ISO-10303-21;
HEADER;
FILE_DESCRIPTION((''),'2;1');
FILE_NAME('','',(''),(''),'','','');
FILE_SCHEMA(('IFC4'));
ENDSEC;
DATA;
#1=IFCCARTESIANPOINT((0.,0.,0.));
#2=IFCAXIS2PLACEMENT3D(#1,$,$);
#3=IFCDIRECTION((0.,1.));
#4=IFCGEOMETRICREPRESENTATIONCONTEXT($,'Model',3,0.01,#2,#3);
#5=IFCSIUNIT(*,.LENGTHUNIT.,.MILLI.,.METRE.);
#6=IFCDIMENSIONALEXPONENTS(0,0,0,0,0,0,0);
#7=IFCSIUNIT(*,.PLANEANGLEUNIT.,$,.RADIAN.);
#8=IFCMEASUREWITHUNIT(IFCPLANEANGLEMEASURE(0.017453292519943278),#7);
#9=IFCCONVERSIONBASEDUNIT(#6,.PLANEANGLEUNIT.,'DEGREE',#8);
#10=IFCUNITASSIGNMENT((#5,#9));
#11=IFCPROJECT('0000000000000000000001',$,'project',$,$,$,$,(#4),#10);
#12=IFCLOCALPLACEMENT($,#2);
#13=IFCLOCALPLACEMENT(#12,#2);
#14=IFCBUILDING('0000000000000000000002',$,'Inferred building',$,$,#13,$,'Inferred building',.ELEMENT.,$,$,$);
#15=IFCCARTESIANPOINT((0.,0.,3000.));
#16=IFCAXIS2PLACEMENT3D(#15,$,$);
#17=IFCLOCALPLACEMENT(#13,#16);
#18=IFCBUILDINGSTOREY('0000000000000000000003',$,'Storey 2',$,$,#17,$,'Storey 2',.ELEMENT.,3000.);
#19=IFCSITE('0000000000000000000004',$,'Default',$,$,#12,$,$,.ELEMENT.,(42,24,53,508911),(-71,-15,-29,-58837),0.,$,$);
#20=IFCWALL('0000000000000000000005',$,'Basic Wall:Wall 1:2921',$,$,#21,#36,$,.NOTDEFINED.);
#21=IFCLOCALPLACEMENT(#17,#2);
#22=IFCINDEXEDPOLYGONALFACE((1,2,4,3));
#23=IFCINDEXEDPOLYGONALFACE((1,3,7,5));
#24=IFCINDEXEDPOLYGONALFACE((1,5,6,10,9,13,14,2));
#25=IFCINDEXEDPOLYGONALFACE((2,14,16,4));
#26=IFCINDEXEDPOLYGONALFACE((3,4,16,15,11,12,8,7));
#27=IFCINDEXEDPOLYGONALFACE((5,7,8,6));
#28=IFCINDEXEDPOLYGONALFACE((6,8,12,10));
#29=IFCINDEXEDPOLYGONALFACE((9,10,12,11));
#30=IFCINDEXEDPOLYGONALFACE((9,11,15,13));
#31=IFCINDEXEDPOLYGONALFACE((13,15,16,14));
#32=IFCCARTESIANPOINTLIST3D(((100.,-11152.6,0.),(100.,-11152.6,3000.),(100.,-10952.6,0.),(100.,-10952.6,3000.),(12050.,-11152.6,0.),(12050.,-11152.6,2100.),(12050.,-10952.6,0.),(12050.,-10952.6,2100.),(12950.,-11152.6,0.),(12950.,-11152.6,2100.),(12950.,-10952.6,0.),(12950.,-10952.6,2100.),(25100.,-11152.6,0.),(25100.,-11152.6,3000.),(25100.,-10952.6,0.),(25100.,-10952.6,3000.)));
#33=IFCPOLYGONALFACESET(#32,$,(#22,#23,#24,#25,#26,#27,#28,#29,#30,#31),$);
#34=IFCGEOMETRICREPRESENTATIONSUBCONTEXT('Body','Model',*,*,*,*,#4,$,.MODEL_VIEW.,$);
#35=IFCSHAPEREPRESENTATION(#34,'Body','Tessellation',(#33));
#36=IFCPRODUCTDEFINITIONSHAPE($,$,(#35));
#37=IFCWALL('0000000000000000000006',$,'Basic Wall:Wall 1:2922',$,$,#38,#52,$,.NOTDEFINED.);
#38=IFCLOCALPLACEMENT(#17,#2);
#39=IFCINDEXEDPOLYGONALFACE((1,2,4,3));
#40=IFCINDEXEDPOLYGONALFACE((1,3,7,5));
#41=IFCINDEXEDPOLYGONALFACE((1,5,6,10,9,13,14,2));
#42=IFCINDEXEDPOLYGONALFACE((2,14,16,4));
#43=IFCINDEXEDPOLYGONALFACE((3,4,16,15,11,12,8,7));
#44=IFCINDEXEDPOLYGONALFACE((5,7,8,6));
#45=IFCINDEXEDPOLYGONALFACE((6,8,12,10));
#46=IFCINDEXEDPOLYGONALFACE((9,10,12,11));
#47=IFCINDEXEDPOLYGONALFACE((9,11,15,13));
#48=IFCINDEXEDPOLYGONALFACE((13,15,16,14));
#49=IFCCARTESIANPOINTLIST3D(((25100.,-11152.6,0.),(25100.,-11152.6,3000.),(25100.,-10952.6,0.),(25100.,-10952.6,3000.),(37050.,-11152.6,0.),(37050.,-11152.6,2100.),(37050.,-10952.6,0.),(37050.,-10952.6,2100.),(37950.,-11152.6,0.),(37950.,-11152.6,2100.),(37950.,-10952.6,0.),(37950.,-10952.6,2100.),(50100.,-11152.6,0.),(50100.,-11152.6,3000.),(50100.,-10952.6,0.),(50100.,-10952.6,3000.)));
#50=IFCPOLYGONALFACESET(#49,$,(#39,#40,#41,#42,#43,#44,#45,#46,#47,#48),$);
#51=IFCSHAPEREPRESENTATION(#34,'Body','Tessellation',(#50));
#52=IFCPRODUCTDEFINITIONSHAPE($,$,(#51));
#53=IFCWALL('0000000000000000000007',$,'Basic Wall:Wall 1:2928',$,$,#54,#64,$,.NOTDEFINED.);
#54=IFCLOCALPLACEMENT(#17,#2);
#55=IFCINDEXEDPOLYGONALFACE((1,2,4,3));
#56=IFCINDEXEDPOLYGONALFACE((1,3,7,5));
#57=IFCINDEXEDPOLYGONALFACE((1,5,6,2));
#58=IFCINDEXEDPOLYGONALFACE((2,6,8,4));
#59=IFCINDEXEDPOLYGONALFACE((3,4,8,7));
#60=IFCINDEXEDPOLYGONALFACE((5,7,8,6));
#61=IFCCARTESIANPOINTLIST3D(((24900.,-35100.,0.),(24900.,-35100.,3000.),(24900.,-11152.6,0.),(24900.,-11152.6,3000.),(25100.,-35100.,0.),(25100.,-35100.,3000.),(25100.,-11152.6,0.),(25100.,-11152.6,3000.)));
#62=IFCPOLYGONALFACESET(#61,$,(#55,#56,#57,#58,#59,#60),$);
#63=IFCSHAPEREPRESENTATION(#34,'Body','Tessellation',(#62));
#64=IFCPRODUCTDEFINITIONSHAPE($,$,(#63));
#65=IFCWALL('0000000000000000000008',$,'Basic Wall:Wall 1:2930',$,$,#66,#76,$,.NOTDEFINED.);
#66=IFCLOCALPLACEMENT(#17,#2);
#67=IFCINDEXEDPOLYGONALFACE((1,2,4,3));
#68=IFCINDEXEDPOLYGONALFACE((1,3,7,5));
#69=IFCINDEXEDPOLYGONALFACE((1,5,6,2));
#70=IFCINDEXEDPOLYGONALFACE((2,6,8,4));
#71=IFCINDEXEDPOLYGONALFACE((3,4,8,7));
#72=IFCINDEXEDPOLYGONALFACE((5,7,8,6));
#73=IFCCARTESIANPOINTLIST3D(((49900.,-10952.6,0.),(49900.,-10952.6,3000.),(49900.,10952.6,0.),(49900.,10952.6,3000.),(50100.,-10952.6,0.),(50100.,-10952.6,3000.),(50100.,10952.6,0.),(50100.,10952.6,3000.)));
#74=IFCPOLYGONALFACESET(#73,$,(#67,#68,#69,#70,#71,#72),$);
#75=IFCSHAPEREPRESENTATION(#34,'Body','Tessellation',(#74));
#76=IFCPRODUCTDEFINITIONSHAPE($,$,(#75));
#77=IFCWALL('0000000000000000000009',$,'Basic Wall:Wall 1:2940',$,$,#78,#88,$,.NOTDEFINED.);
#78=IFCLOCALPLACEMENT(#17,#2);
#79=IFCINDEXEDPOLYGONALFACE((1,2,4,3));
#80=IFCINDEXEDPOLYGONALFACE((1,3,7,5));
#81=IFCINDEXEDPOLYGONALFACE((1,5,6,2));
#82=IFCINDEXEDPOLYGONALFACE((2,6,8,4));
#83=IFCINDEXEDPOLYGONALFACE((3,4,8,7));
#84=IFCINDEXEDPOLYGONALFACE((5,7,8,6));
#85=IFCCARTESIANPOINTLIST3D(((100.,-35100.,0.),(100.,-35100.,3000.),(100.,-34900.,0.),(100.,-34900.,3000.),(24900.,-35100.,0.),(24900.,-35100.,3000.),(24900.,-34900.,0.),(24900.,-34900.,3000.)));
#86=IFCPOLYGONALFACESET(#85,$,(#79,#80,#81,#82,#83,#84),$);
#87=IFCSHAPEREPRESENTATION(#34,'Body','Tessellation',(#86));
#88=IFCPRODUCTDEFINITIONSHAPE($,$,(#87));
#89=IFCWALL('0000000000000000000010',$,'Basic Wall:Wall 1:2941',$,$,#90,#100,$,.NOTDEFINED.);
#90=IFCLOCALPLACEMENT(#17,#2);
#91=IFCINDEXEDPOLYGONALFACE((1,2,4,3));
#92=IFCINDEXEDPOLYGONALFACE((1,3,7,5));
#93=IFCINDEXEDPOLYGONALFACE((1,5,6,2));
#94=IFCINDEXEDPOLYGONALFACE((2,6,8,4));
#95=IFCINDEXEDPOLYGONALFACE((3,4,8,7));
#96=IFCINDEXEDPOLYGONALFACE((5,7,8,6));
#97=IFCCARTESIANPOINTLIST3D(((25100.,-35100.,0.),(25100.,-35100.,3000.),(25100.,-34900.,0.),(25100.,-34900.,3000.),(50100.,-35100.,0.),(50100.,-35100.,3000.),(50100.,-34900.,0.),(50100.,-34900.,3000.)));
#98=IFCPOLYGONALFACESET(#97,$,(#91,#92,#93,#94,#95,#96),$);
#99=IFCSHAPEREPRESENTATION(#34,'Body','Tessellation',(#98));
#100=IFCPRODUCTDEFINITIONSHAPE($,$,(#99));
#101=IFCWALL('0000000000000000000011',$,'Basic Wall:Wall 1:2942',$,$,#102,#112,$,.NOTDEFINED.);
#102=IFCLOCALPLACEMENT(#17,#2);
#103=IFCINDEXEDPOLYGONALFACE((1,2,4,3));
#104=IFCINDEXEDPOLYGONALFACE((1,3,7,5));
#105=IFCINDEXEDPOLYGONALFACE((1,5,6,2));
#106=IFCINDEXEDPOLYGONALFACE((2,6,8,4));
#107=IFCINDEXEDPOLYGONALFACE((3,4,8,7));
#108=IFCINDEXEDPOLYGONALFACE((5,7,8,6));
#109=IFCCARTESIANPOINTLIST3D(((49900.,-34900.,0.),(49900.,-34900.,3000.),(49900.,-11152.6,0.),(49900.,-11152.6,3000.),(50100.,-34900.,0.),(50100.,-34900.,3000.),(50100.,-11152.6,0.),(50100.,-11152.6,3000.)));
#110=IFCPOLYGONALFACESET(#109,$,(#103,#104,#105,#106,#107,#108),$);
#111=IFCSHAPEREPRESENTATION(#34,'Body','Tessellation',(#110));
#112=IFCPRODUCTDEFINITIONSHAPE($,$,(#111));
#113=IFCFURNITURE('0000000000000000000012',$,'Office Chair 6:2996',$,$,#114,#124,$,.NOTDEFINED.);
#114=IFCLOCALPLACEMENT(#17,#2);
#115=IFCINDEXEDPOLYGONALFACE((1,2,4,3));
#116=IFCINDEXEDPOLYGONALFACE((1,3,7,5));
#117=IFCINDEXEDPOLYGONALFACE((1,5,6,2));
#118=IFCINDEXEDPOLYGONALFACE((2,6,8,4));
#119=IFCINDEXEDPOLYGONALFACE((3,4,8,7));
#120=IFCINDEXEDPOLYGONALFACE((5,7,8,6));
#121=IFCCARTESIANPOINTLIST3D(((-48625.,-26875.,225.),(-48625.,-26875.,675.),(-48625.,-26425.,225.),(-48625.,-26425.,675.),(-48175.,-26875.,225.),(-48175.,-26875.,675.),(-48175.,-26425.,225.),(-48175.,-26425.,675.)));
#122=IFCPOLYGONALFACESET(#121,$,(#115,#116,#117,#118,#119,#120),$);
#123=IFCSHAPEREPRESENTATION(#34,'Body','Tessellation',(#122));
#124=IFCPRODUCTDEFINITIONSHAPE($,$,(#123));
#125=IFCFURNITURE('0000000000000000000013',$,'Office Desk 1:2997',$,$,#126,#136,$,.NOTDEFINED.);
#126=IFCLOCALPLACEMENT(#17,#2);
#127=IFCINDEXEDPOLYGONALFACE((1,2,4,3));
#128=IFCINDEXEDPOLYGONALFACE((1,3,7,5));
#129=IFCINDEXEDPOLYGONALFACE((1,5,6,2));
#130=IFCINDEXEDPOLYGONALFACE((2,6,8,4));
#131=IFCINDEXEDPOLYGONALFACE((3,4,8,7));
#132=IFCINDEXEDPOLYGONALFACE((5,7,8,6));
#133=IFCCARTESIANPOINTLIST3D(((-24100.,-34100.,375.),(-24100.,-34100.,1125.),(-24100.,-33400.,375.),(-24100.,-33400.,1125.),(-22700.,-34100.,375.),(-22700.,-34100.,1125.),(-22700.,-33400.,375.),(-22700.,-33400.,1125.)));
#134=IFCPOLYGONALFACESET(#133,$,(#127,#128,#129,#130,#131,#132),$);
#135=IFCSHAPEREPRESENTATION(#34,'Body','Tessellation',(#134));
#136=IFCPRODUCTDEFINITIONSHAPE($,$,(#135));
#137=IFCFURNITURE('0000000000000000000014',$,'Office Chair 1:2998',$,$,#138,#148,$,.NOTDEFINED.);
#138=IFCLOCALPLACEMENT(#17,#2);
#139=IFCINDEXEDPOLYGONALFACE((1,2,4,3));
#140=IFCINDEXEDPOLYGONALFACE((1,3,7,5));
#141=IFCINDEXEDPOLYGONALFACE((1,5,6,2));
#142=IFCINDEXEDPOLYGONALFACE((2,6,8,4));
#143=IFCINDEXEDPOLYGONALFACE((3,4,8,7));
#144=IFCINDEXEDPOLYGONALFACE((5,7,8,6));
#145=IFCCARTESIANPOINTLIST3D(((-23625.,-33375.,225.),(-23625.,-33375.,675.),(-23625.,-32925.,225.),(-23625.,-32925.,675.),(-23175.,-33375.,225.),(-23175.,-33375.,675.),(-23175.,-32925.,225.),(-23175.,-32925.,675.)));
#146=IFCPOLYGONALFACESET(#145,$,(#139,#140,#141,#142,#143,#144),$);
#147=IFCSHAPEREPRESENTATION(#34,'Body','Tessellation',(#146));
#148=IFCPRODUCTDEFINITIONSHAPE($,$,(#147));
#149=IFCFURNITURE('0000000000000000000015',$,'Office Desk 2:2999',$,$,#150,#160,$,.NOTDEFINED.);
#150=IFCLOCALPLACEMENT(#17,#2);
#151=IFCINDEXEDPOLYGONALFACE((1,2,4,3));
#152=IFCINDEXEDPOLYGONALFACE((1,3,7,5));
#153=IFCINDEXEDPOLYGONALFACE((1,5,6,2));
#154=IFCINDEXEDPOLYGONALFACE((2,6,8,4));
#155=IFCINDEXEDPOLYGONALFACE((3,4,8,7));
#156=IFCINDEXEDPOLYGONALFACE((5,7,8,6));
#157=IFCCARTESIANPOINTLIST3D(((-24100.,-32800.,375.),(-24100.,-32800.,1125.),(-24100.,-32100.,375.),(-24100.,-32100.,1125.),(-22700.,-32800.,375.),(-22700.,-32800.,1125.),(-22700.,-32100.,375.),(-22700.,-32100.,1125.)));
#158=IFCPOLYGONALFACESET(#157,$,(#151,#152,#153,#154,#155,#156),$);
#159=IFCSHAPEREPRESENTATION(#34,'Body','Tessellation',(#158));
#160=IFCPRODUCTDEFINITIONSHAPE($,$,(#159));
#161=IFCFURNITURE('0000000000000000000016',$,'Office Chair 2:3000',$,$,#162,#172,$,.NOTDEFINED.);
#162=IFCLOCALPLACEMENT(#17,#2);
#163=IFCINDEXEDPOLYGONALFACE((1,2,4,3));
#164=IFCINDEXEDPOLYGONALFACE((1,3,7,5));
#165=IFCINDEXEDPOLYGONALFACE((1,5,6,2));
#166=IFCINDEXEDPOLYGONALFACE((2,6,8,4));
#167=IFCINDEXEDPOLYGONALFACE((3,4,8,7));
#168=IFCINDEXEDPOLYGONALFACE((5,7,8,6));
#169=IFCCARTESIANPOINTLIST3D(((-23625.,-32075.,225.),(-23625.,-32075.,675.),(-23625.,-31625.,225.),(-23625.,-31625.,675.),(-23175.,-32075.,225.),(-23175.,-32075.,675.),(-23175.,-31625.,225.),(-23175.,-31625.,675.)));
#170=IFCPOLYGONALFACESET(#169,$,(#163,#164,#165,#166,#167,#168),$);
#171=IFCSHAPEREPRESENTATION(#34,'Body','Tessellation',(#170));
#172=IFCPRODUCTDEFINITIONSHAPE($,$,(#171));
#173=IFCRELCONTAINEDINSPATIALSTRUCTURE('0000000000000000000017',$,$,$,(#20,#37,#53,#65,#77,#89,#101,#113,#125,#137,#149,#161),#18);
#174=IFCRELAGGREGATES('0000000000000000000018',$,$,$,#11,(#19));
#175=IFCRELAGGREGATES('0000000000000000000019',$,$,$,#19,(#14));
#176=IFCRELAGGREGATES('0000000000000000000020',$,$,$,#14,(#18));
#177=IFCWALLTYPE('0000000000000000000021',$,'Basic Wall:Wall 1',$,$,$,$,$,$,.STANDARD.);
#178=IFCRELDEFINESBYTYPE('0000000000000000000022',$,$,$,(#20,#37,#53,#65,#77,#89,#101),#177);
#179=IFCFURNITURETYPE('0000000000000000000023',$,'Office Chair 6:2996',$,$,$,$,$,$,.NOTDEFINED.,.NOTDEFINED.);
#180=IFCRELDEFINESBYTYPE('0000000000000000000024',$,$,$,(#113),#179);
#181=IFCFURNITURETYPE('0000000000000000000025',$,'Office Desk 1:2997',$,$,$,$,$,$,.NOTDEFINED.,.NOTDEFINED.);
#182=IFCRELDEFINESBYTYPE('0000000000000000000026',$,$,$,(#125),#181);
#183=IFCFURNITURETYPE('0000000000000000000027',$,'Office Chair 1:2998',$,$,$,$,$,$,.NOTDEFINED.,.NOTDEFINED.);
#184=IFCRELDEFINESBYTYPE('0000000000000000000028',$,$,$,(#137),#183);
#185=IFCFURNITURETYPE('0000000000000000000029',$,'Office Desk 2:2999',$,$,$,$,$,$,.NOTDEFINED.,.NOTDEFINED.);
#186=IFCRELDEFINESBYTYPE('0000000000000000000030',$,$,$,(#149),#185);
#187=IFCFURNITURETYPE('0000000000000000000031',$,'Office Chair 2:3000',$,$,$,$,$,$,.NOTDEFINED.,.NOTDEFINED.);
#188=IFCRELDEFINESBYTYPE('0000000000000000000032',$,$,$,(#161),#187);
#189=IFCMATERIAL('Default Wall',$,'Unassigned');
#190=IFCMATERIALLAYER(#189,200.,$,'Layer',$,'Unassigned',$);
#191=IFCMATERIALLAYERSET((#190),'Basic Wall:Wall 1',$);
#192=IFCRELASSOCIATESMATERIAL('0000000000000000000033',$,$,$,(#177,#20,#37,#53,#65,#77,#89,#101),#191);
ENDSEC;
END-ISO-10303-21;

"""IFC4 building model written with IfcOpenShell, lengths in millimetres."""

from ifc_helpers import new_model, entity, si_unit, converted_unit, direction, frame, frame_2d, origin, origin_2d_with_axis, place, context, subcontext, project, spatial, rectangle, extrude, material, layer, layer_set, layer_usage, type_object, element, save


model = new_model("IFC4")

# Units and contexts
model_context = context("Model", 3, precision=0.01, world=origin(), true_north=direction((0.0, 1.0)))
body_context = subcontext(model_context, "Body", "Model", "MODEL_VIEW")
ifc_project = project(units=[si_unit("LENGTHUNIT", "METRE", prefix="MILLI"), converted_unit("PLANEANGLEUNIT", "DEGREE", entity("IfcPlaneAngleMeasure", 0.017453292519943278), si_unit("PLANEANGLEUNIT", "RADIAN"), dimensions=[0, 0, 0, 0, 0, 0, 0])], contexts=[model_context])

# Site, building, storey
site_placement = place(None, origin())
site = spatial("IfcSite", under=ifc_project, at=site_placement, Name="Default", CompositionType="ELEMENT", RefLatitude=(42, 24, 53, 508911), RefLongitude=(-71, -15, -29, -58837), RefElevation=0.0)
building_placement = place(site_placement, origin())
building = spatial("IfcBuilding", under=site, at=building_placement, Name="Inferred building", LongName="Inferred building", CompositionType="ELEMENT")
storey_placement = place(building_placement, frame((0.0, 0.0, 3000.0)))
storey = spatial("IfcBuildingStorey", under=building, at=storey_placement, Name="Storey 2", LongName="Storey 2", CompositionType="ELEMENT", Elevation=3000.0)

# Walls, openings
ifc_material = material(Name="Default Wall", Category="Unassigned")
ifc_layer = layer(ifc_material, 200.0, Name="Layer", Category="Unassigned")
ifc_layer_set = layer_set([ifc_layer], Name="Basic Wall:Wall 1")
ifc_layer_usage_1 = layer_usage(ifc_layer_set, "AXIS2", "NEGATIVE", 100.0)
wall_type = type_object("IfcWallType", Name="Basic Wall:Wall 1", PredefinedType="STANDARD", material=ifc_layer_set)
wall_1_placement = place(storey_placement, frame((100.0, -11052.6, 0.0)))
wall_1 = element("IfcWall", 1, at=wall_1_placement, inside=storey, type_object=wall_type, material=ifc_layer_usage_1, Name="Basic Wall:Wall 1:2921", PredefinedType="NOTDEFINED", context=body_context, shape_type="SweptSolid", body=[
    extrude(rectangle(XDim=25000.0, YDim=200.0, at=frame_2d((12500.0, 0.0), x_axis=(-1.0, 0.0))), origin(), (0.0, 0.0, 1.0), 3000.0),
])
opening_1_placement = place(wall_1_placement, origin())
element("IfcOpeningElement", 2, at=opening_1_placement, cuts=wall_1, PredefinedType="OPENING", context=body_context, shape_type="SweptSolid", body=[
    extrude(rectangle(XDim=2100.0, YDim=900.0, at=frame_2d((0.0, 0.0), x_axis=(1.0, 0.0))), frame((12400.0, -100.0, 1050.0), z_axis=(0.0, 1.0, 0.0), x_axis=(0.0, 0.0, -1.0)), (0.0, 0.0, 1.0), 200.0),
])
ifc_layer_usage_2 = layer_usage(ifc_layer_set, "AXIS2", "NEGATIVE", 100.0)
wall_2_placement = place(storey_placement, frame((25100.0, -11052.6, 0.0)))
wall_2 = element("IfcWall", 3, at=wall_2_placement, inside=storey, type_object=wall_type, material=ifc_layer_usage_2, Name="Basic Wall:Wall 1:2922", PredefinedType="NOTDEFINED", context=body_context, shape_type="SweptSolid", body=[
    extrude(rectangle(XDim=25000.0, YDim=200.0, at=frame_2d((12500.0, 0.0), x_axis=(-1.0, 0.0))), origin(), (0.0, 0.0, 1.0), 3000.0),
])
opening_2_placement = place(wall_2_placement, origin())
element("IfcOpeningElement", 4, at=opening_2_placement, cuts=wall_2, PredefinedType="OPENING", context=body_context, shape_type="SweptSolid", body=[
    extrude(rectangle(XDim=2100.0, YDim=900.0, at=frame_2d((0.0, 0.0), x_axis=(1.0, 0.0))), frame((12400.0, -100.0, 1050.0), z_axis=(0.0, 1.0, 0.0), x_axis=(0.0, 0.0, -1.0)), (0.0, 0.0, 1.0), 200.0),
])

# Walls
ifc_layer_usage_3 = layer_usage(ifc_layer_set, "AXIS2", "NEGATIVE", 100.0)
wall_3_placement = place(storey_placement, frame((25000.0, -35100.0, 0.0), z_axis=(0.0, 0.0, 1.0), x_axis=(0.0, 1.0, 0.0)))
element("IfcWall", 5, at=wall_3_placement, inside=storey, type_object=wall_type, material=ifc_layer_usage_3, Name="Basic Wall:Wall 1:2928", PredefinedType="NOTDEFINED", context=body_context, shape_type="SweptSolid", body=[
    extrude(rectangle(XDim=23947.4, YDim=200.0, at=frame_2d((11973.7, 0.0), x_axis=(-1.0, 0.0))), origin(), (0.0, 0.0, 1.0), 3000.0),
])
ifc_layer_usage_4 = layer_usage(ifc_layer_set, "AXIS2", "NEGATIVE", 100.0)
wall_4_placement = place(storey_placement, frame((50000.0, -10952.6, 0.0), z_axis=(0.0, 0.0, 1.0), x_axis=(0.0, 1.0, 0.0)))
element("IfcWall", 6, at=wall_4_placement, inside=storey, type_object=wall_type, material=ifc_layer_usage_4, Name="Basic Wall:Wall 1:2930", PredefinedType="NOTDEFINED", context=body_context, shape_type="SweptSolid", body=[
    extrude(rectangle(XDim=21905.3, YDim=200.0, at=frame_2d((10952.6, 0.0), x_axis=(-1.0, 0.0))), origin(), (0.0, 0.0, 1.0), 3000.0),
])
ifc_layer_usage_5 = layer_usage(ifc_layer_set, "AXIS2", "NEGATIVE", 100.0)
wall_5_placement = place(storey_placement, frame((100.0, -35000.0, 0.0)))
element("IfcWall", 7, at=wall_5_placement, inside=storey, type_object=wall_type, material=ifc_layer_usage_5, Name="Basic Wall:Wall 1:2940", PredefinedType="NOTDEFINED", context=body_context, shape_type="SweptSolid", body=[
    extrude(rectangle(XDim=24800.0, YDim=200.0, at=frame_2d((12400.0, 0.0), x_axis=(-1.0, 0.0))), origin(), (0.0, 0.0, 1.0), 3000.0),
])
ifc_layer_usage_6 = layer_usage(ifc_layer_set, "AXIS2", "NEGATIVE", 100.0)
wall_6_placement = place(storey_placement, frame((25100.0, -35000.0, 0.0)))
element("IfcWall", 8, at=wall_6_placement, inside=storey, type_object=wall_type, material=ifc_layer_usage_6, Name="Basic Wall:Wall 1:2941", PredefinedType="NOTDEFINED", context=body_context, shape_type="SweptSolid", body=[
    extrude(rectangle(XDim=25000.0, YDim=200.0, at=frame_2d((12500.0, 0.0), x_axis=(-1.0, 0.0))), origin(), (0.0, 0.0, 1.0), 3000.0),
])
ifc_layer_usage_7 = layer_usage(ifc_layer_set, "AXIS2", "NEGATIVE", 100.0)
wall_7_placement = place(storey_placement, frame((50000.0, -34900.0, 0.0), z_axis=(0.0, 0.0, 1.0), x_axis=(0.0, 1.0, 0.0)))
element("IfcWall", 9, at=wall_7_placement, inside=storey, type_object=wall_type, material=ifc_layer_usage_7, Name="Basic Wall:Wall 1:2942", PredefinedType="NOTDEFINED", context=body_context, shape_type="SweptSolid", body=[
    extrude(rectangle(XDim=23747.4, YDim=200.0, at=frame_2d((11873.7, 0.0), x_axis=(-1.0, 0.0))), origin(), (0.0, 0.0, 1.0), 3000.0),
])

# Furniture
furniture_type_1 = type_object("IfcFurnitureType", Name="Office Chair 6:2996", PredefinedType="NOTDEFINED")
furniture_1_placement = place(storey_placement, origin())
element("IfcFurniture", 10, at=furniture_1_placement, inside=storey, type_object=furniture_type_1, Name="Office Chair 6:2996", PredefinedType="NOTDEFINED", context=body_context, shape_type="SweptSolid", body=[
    extrude(rectangle(XDim=450.0, YDim=450.0, at=origin_2d_with_axis()), frame((-48400.0, -26650.0, 225.0)), (0.0, 0.0, 1.0), 450.0),
])
furniture_type_2 = type_object("IfcFurnitureType", Name="Office Desk 1:2997", PredefinedType="NOTDEFINED")
furniture_2_placement = place(storey_placement, origin())
element("IfcFurniture", 11, at=furniture_2_placement, inside=storey, type_object=furniture_type_2, Name="Office Desk 1:2997", PredefinedType="NOTDEFINED", context=body_context, shape_type="SweptSolid", body=[
    extrude(rectangle(XDim=1400.0, YDim=700.0, at=origin_2d_with_axis()), frame((-23400.0, -33750.0, 375.0)), (0.0, 0.0, 1.0), 750.0),
])
furniture_type_3 = type_object("IfcFurnitureType", Name="Office Chair 1:2998", PredefinedType="NOTDEFINED")
furniture_3_placement = place(storey_placement, origin())
element("IfcFurniture", 12, at=furniture_3_placement, inside=storey, type_object=furniture_type_3, Name="Office Chair 1:2998", PredefinedType="NOTDEFINED", context=body_context, shape_type="SweptSolid", body=[
    extrude(rectangle(XDim=450.0, YDim=450.0, at=origin_2d_with_axis()), frame((-23400.0, -33150.0, 225.0)), (0.0, 0.0, 1.0), 450.0),
])
furniture_type_4 = type_object("IfcFurnitureType", Name="Office Desk 2:2999", PredefinedType="NOTDEFINED")
furniture_4_placement = place(storey_placement, origin())
element("IfcFurniture", 13, at=furniture_4_placement, inside=storey, type_object=furniture_type_4, Name="Office Desk 2:2999", PredefinedType="NOTDEFINED", context=body_context, shape_type="SweptSolid", body=[
    extrude(rectangle(XDim=1400.0, YDim=700.0, at=origin_2d_with_axis()), frame((-23400.0, -32450.0, 375.0)), (0.0, 0.0, 1.0), 750.0),
])
furniture_type_5 = type_object("IfcFurnitureType", Name="Office Chair 2:3000", PredefinedType="NOTDEFINED")
furniture_5_placement = place(storey_placement, origin())
element("IfcFurniture", 14, at=furniture_5_placement, inside=storey, type_object=furniture_type_5, Name="Office Chair 2:3000", PredefinedType="NOTDEFINED", context=body_context, shape_type="SweptSolid", body=[
    extrude(rectangle(XDim=450.0, YDim=450.0, at=origin_2d_with_axis()), frame((-23400.0, -31850.0, 225.0)), (0.0, 0.0, 1.0), 450.0),
])

save(model, "model.ifc")
